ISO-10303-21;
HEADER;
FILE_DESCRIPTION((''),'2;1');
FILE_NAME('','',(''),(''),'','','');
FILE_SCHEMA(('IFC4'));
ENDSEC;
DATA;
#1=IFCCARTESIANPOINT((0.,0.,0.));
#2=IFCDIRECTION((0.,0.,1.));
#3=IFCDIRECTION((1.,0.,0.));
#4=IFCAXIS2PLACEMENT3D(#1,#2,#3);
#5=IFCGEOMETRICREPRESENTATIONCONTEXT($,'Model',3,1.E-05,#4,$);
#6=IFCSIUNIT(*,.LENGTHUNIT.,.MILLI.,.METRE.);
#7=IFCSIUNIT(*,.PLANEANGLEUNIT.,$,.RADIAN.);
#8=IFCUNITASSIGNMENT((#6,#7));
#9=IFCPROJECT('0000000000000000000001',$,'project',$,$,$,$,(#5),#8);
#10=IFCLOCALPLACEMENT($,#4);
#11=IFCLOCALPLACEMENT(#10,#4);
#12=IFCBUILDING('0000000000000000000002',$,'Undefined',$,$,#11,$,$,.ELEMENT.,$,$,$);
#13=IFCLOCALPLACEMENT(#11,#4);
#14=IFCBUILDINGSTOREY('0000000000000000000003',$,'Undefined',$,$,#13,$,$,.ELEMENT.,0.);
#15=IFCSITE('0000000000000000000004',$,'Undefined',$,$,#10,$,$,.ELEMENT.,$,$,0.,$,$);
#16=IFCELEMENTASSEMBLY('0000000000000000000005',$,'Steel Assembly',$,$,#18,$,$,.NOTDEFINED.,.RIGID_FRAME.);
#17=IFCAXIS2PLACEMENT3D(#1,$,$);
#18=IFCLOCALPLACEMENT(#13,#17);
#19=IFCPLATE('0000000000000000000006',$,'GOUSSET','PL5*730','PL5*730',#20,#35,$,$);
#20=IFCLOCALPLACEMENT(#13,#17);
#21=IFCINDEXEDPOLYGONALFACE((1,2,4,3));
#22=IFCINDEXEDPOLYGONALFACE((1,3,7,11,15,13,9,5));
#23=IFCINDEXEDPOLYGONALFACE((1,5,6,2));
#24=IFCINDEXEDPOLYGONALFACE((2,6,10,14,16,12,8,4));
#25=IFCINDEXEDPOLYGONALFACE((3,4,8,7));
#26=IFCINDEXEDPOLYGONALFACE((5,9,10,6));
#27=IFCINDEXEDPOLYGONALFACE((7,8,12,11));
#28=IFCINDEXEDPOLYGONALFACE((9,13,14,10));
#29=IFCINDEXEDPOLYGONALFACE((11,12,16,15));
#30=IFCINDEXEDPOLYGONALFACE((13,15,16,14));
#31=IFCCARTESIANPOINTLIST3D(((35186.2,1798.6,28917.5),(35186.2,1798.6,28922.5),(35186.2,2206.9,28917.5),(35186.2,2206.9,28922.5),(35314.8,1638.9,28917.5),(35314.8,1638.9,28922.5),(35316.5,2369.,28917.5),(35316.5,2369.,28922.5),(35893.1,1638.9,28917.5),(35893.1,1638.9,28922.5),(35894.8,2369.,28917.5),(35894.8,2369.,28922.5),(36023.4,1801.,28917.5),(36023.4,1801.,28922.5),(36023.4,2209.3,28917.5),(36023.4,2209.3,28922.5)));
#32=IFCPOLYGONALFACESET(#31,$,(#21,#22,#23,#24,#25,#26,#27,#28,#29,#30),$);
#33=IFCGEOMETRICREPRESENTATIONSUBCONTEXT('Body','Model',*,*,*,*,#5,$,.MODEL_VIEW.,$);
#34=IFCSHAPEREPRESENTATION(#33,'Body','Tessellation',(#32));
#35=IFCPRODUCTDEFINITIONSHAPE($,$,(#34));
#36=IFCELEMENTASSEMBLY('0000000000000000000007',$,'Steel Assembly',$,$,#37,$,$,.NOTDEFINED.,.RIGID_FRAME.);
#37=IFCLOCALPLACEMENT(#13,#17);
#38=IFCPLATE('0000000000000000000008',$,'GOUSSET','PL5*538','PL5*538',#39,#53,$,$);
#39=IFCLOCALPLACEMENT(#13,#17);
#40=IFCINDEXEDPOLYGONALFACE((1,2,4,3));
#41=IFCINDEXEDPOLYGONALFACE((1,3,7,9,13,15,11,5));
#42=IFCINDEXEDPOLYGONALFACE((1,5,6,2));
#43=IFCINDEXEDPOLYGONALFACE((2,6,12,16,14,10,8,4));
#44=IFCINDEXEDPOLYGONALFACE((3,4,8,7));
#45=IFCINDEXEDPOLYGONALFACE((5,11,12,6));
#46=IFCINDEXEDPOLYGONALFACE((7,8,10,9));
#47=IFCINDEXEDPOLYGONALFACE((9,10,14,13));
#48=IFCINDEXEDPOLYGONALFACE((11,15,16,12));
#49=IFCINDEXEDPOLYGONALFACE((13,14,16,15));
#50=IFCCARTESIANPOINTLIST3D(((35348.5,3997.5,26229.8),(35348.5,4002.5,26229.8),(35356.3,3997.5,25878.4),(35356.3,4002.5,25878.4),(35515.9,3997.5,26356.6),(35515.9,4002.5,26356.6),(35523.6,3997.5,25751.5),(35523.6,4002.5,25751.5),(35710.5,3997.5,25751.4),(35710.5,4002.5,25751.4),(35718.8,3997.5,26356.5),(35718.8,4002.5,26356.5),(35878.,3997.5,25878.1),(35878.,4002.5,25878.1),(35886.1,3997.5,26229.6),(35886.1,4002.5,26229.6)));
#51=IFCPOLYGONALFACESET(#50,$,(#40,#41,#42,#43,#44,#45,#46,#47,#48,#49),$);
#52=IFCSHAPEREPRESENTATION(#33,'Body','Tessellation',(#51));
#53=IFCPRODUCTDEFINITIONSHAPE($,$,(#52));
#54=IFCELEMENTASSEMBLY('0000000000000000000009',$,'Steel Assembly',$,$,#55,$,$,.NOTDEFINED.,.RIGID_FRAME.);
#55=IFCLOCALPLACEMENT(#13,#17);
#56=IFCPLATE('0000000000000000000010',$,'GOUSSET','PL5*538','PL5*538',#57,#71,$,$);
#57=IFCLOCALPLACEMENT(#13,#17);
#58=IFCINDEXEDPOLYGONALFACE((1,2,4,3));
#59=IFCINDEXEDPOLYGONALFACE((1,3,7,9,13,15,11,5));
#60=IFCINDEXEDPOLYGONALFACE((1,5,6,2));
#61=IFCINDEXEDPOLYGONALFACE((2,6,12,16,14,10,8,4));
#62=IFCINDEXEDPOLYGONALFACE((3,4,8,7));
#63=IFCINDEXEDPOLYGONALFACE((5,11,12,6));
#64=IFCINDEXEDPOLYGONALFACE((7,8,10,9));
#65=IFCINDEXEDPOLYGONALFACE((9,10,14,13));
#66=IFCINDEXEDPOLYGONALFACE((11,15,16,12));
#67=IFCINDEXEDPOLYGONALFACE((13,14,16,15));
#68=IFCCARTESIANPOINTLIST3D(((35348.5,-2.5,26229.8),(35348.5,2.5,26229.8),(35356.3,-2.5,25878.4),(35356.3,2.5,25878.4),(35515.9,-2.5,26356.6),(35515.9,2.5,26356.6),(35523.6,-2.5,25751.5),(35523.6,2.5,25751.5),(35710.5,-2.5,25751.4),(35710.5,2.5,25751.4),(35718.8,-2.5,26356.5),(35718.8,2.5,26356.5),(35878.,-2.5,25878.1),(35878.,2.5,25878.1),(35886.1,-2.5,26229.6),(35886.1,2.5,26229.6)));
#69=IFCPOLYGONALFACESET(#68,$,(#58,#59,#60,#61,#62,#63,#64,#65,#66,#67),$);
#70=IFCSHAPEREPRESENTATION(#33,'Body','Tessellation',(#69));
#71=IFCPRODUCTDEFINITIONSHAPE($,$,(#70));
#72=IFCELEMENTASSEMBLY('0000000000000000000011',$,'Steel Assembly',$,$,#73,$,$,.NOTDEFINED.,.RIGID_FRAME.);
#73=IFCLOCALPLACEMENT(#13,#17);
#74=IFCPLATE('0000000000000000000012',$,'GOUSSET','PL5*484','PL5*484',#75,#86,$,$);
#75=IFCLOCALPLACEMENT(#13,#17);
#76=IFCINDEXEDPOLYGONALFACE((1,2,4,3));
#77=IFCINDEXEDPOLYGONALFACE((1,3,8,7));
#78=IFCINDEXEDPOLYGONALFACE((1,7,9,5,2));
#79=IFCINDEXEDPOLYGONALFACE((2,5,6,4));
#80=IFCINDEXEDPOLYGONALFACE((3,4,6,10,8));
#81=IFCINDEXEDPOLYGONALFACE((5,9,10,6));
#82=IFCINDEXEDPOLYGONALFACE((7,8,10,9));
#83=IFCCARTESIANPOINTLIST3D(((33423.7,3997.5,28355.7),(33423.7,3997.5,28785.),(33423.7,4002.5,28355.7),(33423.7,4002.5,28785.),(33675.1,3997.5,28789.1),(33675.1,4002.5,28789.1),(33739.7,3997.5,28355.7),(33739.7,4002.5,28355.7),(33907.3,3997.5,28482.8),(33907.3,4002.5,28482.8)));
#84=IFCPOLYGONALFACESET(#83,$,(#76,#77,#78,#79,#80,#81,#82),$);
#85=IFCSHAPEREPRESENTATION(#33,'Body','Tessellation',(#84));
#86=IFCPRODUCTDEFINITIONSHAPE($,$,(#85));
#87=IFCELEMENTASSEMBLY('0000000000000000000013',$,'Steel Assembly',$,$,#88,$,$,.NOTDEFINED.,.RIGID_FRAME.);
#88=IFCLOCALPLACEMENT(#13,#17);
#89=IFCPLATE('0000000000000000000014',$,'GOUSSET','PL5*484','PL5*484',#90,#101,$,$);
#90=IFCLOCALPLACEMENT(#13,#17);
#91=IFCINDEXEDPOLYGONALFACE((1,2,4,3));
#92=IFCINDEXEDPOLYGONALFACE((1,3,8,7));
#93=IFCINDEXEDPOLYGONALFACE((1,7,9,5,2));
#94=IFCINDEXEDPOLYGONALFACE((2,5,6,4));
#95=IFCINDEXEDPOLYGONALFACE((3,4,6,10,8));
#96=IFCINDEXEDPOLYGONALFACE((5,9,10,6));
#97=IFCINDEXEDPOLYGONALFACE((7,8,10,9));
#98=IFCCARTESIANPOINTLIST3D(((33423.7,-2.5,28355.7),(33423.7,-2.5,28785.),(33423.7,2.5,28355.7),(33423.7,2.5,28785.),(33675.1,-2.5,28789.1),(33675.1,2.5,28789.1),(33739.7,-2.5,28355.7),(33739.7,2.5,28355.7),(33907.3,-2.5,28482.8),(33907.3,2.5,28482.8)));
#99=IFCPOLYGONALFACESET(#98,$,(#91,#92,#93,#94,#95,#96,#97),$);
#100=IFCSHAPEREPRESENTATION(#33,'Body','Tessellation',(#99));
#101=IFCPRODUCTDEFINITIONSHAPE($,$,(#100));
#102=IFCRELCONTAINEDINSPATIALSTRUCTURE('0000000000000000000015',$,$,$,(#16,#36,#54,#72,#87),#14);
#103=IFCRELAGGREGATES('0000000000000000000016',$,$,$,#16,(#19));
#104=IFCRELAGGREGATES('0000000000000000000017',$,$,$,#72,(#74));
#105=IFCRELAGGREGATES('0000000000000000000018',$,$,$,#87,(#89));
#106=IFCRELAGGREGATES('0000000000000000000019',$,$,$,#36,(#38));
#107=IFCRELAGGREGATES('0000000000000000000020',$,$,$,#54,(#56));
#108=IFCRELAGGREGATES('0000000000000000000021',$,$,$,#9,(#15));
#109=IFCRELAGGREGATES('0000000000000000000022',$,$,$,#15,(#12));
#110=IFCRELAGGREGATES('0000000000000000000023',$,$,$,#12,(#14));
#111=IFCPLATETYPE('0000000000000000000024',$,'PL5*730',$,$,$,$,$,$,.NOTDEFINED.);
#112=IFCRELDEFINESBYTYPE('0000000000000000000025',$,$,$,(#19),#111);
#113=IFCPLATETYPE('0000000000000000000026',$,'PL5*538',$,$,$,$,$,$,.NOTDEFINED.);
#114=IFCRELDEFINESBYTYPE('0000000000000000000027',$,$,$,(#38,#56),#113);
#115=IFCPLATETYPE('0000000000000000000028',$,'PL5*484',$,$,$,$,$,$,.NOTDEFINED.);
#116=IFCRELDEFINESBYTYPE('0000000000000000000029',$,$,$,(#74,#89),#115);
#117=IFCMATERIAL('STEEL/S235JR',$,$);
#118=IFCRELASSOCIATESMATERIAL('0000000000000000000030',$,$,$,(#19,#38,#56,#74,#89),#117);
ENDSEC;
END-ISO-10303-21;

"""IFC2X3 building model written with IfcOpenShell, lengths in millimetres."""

from ifc_helpers import new_model, si_unit, frame, origin_with_axes, place, context, subcontext, project, spatial, polyline, outline, extrude, material, type_object, element, aggregate, save


model = new_model("IFC2X3")

# Units and contexts
model_context = context("Model", 3, precision=1e-05, world=origin_with_axes())
body_context = subcontext(model_context, "Body", "Model", "MODEL_VIEW")
ifc_project = project(units=[si_unit("LENGTHUNIT", "METRE", prefix="MILLI"), si_unit("PLANEANGLEUNIT", "RADIAN")], contexts=[model_context])

# Site, building, storey
site_placement = place(None, origin_with_axes())
site = spatial("IfcSite", under=ifc_project, at=site_placement, Name="Undefined", CompositionType="ELEMENT", RefElevation=0.0)
building_placement = place(site_placement, origin_with_axes())
building = spatial("IfcBuilding", under=site, at=building_placement, Name="Undefined", CompositionType="ELEMENT")
storey_placement = place(building_placement, origin_with_axes())
storey = spatial("IfcBuildingStorey", under=building, at=storey_placement, Name="Undefined", CompositionType="ELEMENT", Elevation=0.0)

# Shared definitions
ifc_material_1 = material(Name="STEEL/S235JR")

# Element assemblies, plates
assembly_1_placement = place(storey_placement, origin_with_axes())
assembly_1 = element("IfcElementAssembly", 1, at=assembly_1_placement, inside=storey, Name="Steel Assembly", AssemblyPlace="NOTDEFINED", PredefinedType="RIGID_FRAME")
plate_type_1 = type_object("IfcPlateType", Name="PL5*730", PredefinedType="NOTDEFINED")
plate_1_placement = place(assembly_1_placement, frame((35316.5, 2369.0, 28920.0), z_axis=(0.0, 0.0, -1.0), x_axis=(1.0, 0.0, 0.0)))
plate_1 = element("IfcPlate", 2, at=plate_1_placement, type_object=plate_type_1, material=ifc_material_1, Name="GOUSSET", Description="PL5*730", ObjectType="PL5*730", context=body_context, shape_type="SweptSolid", body=[
    extrude(outline(polyline([(0.0, 0.0), (578.4, 0.0), (706.9, 159.7), (706.9, 568.0), (576.6, 730.1), (-1.7, 730.1), (-130.3, 570.5), (-130.3, 162.1), (0.0, 0.0)])), frame((0.0, 0.0, -2.5), z_axis=(0.0, 0.0, 1.0), x_axis=(1.0, 0.0, 0.0)), (0.0, 0.0, 1.0), 5.0),
])
assembly_2_placement = place(storey_placement, origin_with_axes())
assembly_2 = element("IfcElementAssembly", 3, at=assembly_2_placement, inside=storey, Name="Steel Assembly", AssemblyPlace="NOTDEFINED", PredefinedType="RIGID_FRAME")
plate_type_2 = type_object("IfcPlateType", Name="PL5*538", PredefinedType="NOTDEFINED")
plate_2_placement = place(assembly_2_placement, frame((35515.9, 4000.0, 26356.6), z_axis=(0.0, 1.0, 0.0), x_axis=(1.0, 0.0, -0.000493)))
plate_2 = element("IfcPlate", 4, at=plate_2_placement, type_object=plate_type_2, material=ifc_material_1, Name="GOUSSET", Description="PL5*538", ObjectType="PL5*538", context=body_context, shape_type="SweptSolid", body=[
    extrude(outline(polyline([(0.0, 0.0), (202.9, 0.0), (370.3, 126.8), (362.3, 478.3), (194.9, 605.1), (8.0, 605.1), (-159.4, 478.3), (-167.4, 126.8), (0.0, 0.0)])), frame((0.0, 0.0, -2.5), z_axis=(0.0, 0.0, 1.0), x_axis=(1.0, 0.0, 0.0)), (0.0, 0.0, 1.0), 5.0),
])
assembly_3_placement = place(storey_placement, origin_with_axes())
assembly_3 = element("IfcElementAssembly", 5, at=assembly_3_placement, inside=storey, Name="Steel Assembly", AssemblyPlace="NOTDEFINED", PredefinedType="RIGID_FRAME")
plate_3_placement = place(assembly_3_placement, frame((35515.9, 0.0, 26356.6), z_axis=(0.0, 1.0, 0.0), x_axis=(1.0, 0.0, -0.000493)))
plate_3 = element("IfcPlate", 6, at=plate_3_placement, type_object=plate_type_2, material=ifc_material_1, Name="GOUSSET", Description="PL5*538", ObjectType="PL5*538", context=body_context, shape_type="SweptSolid", body=[
    extrude(outline(polyline([(0.0, 0.0), (202.9, 0.0), (370.3, 126.8), (362.3, 478.3), (194.9, 605.1), (8.0, 605.1), (-159.4, 478.3), (-167.4, 126.8), (0.0, 0.0)])), frame((0.0, 0.0, -2.5), z_axis=(0.0, 0.0, 1.0), x_axis=(1.0, 0.0, 0.0)), (0.0, 0.0, 1.0), 5.0),
])
assembly_4_placement = place(storey_placement, origin_with_axes())
assembly_4 = element("IfcElementAssembly", 7, at=assembly_4_placement, inside=storey, Name="Steel Assembly", AssemblyPlace="NOTDEFINED", PredefinedType="RIGID_FRAME")
plate_type_3 = type_object("IfcPlateType", Name="PL5*484", PredefinedType="NOTDEFINED")
plate_4_placement = place(assembly_4_placement, frame((33675.1, 4000.0, 28789.1), z_axis=(0.0, -1.0, 0.0), x_axis=(-0.999868, 0.0, -0.016223)))
plate_4 = element("IfcPlate", 8, at=plate_4_placement, type_object=plate_type_3, material=ifc_material_1, Name="GOUSSET", Description="PL5*484", ObjectType="PL5*484", context=body_context, shape_type="SweptSolid", body=[
    extrude(outline(polyline([(0.0, 0.0), (251.4, 0.0), (258.3, 429.3), (-57.6, 434.4), (-227.3, 310.0), (0.0, 0.0)])), frame((0.0, 0.0, -2.5), z_axis=(0.0, 0.0, 1.0), x_axis=(1.0, 0.0, 0.0)), (0.0, 0.0, 1.0), 5.0),
])
assembly_5_placement = place(storey_placement, origin_with_axes())
assembly_5 = element("IfcElementAssembly", 9, at=assembly_5_placement, inside=storey, Name="Steel Assembly", AssemblyPlace="NOTDEFINED", PredefinedType="RIGID_FRAME")
plate_5_placement = place(assembly_5_placement, frame((33675.1, 0.0, 28789.1), z_axis=(0.0, -1.0, 0.0), x_axis=(-0.999868, 0.0, -0.016223)))
plate_5 = element("IfcPlate", 10, at=plate_5_placement, type_object=plate_type_3, material=ifc_material_1, Name="GOUSSET", Description="PL5*484", ObjectType="PL5*484", context=body_context, shape_type="SweptSolid", body=[
    extrude(outline(polyline([(0.0, 0.0), (251.4, 0.0), (258.3, 429.3), (-57.6, 434.4), (-227.3, 310.0), (0.0, 0.0)])), frame((0.0, 0.0, -2.5), z_axis=(0.0, 0.0, 1.0), x_axis=(1.0, 0.0, 0.0)), (0.0, 0.0, 1.0), 5.0),
])

aggregate(assembly_1, [plate_1])

aggregate(assembly_4, [plate_4])
aggregate(assembly_5, [plate_5])
aggregate(assembly_2, [plate_2])
aggregate(assembly_3, [plate_3])

save(model, "model.ifc")
